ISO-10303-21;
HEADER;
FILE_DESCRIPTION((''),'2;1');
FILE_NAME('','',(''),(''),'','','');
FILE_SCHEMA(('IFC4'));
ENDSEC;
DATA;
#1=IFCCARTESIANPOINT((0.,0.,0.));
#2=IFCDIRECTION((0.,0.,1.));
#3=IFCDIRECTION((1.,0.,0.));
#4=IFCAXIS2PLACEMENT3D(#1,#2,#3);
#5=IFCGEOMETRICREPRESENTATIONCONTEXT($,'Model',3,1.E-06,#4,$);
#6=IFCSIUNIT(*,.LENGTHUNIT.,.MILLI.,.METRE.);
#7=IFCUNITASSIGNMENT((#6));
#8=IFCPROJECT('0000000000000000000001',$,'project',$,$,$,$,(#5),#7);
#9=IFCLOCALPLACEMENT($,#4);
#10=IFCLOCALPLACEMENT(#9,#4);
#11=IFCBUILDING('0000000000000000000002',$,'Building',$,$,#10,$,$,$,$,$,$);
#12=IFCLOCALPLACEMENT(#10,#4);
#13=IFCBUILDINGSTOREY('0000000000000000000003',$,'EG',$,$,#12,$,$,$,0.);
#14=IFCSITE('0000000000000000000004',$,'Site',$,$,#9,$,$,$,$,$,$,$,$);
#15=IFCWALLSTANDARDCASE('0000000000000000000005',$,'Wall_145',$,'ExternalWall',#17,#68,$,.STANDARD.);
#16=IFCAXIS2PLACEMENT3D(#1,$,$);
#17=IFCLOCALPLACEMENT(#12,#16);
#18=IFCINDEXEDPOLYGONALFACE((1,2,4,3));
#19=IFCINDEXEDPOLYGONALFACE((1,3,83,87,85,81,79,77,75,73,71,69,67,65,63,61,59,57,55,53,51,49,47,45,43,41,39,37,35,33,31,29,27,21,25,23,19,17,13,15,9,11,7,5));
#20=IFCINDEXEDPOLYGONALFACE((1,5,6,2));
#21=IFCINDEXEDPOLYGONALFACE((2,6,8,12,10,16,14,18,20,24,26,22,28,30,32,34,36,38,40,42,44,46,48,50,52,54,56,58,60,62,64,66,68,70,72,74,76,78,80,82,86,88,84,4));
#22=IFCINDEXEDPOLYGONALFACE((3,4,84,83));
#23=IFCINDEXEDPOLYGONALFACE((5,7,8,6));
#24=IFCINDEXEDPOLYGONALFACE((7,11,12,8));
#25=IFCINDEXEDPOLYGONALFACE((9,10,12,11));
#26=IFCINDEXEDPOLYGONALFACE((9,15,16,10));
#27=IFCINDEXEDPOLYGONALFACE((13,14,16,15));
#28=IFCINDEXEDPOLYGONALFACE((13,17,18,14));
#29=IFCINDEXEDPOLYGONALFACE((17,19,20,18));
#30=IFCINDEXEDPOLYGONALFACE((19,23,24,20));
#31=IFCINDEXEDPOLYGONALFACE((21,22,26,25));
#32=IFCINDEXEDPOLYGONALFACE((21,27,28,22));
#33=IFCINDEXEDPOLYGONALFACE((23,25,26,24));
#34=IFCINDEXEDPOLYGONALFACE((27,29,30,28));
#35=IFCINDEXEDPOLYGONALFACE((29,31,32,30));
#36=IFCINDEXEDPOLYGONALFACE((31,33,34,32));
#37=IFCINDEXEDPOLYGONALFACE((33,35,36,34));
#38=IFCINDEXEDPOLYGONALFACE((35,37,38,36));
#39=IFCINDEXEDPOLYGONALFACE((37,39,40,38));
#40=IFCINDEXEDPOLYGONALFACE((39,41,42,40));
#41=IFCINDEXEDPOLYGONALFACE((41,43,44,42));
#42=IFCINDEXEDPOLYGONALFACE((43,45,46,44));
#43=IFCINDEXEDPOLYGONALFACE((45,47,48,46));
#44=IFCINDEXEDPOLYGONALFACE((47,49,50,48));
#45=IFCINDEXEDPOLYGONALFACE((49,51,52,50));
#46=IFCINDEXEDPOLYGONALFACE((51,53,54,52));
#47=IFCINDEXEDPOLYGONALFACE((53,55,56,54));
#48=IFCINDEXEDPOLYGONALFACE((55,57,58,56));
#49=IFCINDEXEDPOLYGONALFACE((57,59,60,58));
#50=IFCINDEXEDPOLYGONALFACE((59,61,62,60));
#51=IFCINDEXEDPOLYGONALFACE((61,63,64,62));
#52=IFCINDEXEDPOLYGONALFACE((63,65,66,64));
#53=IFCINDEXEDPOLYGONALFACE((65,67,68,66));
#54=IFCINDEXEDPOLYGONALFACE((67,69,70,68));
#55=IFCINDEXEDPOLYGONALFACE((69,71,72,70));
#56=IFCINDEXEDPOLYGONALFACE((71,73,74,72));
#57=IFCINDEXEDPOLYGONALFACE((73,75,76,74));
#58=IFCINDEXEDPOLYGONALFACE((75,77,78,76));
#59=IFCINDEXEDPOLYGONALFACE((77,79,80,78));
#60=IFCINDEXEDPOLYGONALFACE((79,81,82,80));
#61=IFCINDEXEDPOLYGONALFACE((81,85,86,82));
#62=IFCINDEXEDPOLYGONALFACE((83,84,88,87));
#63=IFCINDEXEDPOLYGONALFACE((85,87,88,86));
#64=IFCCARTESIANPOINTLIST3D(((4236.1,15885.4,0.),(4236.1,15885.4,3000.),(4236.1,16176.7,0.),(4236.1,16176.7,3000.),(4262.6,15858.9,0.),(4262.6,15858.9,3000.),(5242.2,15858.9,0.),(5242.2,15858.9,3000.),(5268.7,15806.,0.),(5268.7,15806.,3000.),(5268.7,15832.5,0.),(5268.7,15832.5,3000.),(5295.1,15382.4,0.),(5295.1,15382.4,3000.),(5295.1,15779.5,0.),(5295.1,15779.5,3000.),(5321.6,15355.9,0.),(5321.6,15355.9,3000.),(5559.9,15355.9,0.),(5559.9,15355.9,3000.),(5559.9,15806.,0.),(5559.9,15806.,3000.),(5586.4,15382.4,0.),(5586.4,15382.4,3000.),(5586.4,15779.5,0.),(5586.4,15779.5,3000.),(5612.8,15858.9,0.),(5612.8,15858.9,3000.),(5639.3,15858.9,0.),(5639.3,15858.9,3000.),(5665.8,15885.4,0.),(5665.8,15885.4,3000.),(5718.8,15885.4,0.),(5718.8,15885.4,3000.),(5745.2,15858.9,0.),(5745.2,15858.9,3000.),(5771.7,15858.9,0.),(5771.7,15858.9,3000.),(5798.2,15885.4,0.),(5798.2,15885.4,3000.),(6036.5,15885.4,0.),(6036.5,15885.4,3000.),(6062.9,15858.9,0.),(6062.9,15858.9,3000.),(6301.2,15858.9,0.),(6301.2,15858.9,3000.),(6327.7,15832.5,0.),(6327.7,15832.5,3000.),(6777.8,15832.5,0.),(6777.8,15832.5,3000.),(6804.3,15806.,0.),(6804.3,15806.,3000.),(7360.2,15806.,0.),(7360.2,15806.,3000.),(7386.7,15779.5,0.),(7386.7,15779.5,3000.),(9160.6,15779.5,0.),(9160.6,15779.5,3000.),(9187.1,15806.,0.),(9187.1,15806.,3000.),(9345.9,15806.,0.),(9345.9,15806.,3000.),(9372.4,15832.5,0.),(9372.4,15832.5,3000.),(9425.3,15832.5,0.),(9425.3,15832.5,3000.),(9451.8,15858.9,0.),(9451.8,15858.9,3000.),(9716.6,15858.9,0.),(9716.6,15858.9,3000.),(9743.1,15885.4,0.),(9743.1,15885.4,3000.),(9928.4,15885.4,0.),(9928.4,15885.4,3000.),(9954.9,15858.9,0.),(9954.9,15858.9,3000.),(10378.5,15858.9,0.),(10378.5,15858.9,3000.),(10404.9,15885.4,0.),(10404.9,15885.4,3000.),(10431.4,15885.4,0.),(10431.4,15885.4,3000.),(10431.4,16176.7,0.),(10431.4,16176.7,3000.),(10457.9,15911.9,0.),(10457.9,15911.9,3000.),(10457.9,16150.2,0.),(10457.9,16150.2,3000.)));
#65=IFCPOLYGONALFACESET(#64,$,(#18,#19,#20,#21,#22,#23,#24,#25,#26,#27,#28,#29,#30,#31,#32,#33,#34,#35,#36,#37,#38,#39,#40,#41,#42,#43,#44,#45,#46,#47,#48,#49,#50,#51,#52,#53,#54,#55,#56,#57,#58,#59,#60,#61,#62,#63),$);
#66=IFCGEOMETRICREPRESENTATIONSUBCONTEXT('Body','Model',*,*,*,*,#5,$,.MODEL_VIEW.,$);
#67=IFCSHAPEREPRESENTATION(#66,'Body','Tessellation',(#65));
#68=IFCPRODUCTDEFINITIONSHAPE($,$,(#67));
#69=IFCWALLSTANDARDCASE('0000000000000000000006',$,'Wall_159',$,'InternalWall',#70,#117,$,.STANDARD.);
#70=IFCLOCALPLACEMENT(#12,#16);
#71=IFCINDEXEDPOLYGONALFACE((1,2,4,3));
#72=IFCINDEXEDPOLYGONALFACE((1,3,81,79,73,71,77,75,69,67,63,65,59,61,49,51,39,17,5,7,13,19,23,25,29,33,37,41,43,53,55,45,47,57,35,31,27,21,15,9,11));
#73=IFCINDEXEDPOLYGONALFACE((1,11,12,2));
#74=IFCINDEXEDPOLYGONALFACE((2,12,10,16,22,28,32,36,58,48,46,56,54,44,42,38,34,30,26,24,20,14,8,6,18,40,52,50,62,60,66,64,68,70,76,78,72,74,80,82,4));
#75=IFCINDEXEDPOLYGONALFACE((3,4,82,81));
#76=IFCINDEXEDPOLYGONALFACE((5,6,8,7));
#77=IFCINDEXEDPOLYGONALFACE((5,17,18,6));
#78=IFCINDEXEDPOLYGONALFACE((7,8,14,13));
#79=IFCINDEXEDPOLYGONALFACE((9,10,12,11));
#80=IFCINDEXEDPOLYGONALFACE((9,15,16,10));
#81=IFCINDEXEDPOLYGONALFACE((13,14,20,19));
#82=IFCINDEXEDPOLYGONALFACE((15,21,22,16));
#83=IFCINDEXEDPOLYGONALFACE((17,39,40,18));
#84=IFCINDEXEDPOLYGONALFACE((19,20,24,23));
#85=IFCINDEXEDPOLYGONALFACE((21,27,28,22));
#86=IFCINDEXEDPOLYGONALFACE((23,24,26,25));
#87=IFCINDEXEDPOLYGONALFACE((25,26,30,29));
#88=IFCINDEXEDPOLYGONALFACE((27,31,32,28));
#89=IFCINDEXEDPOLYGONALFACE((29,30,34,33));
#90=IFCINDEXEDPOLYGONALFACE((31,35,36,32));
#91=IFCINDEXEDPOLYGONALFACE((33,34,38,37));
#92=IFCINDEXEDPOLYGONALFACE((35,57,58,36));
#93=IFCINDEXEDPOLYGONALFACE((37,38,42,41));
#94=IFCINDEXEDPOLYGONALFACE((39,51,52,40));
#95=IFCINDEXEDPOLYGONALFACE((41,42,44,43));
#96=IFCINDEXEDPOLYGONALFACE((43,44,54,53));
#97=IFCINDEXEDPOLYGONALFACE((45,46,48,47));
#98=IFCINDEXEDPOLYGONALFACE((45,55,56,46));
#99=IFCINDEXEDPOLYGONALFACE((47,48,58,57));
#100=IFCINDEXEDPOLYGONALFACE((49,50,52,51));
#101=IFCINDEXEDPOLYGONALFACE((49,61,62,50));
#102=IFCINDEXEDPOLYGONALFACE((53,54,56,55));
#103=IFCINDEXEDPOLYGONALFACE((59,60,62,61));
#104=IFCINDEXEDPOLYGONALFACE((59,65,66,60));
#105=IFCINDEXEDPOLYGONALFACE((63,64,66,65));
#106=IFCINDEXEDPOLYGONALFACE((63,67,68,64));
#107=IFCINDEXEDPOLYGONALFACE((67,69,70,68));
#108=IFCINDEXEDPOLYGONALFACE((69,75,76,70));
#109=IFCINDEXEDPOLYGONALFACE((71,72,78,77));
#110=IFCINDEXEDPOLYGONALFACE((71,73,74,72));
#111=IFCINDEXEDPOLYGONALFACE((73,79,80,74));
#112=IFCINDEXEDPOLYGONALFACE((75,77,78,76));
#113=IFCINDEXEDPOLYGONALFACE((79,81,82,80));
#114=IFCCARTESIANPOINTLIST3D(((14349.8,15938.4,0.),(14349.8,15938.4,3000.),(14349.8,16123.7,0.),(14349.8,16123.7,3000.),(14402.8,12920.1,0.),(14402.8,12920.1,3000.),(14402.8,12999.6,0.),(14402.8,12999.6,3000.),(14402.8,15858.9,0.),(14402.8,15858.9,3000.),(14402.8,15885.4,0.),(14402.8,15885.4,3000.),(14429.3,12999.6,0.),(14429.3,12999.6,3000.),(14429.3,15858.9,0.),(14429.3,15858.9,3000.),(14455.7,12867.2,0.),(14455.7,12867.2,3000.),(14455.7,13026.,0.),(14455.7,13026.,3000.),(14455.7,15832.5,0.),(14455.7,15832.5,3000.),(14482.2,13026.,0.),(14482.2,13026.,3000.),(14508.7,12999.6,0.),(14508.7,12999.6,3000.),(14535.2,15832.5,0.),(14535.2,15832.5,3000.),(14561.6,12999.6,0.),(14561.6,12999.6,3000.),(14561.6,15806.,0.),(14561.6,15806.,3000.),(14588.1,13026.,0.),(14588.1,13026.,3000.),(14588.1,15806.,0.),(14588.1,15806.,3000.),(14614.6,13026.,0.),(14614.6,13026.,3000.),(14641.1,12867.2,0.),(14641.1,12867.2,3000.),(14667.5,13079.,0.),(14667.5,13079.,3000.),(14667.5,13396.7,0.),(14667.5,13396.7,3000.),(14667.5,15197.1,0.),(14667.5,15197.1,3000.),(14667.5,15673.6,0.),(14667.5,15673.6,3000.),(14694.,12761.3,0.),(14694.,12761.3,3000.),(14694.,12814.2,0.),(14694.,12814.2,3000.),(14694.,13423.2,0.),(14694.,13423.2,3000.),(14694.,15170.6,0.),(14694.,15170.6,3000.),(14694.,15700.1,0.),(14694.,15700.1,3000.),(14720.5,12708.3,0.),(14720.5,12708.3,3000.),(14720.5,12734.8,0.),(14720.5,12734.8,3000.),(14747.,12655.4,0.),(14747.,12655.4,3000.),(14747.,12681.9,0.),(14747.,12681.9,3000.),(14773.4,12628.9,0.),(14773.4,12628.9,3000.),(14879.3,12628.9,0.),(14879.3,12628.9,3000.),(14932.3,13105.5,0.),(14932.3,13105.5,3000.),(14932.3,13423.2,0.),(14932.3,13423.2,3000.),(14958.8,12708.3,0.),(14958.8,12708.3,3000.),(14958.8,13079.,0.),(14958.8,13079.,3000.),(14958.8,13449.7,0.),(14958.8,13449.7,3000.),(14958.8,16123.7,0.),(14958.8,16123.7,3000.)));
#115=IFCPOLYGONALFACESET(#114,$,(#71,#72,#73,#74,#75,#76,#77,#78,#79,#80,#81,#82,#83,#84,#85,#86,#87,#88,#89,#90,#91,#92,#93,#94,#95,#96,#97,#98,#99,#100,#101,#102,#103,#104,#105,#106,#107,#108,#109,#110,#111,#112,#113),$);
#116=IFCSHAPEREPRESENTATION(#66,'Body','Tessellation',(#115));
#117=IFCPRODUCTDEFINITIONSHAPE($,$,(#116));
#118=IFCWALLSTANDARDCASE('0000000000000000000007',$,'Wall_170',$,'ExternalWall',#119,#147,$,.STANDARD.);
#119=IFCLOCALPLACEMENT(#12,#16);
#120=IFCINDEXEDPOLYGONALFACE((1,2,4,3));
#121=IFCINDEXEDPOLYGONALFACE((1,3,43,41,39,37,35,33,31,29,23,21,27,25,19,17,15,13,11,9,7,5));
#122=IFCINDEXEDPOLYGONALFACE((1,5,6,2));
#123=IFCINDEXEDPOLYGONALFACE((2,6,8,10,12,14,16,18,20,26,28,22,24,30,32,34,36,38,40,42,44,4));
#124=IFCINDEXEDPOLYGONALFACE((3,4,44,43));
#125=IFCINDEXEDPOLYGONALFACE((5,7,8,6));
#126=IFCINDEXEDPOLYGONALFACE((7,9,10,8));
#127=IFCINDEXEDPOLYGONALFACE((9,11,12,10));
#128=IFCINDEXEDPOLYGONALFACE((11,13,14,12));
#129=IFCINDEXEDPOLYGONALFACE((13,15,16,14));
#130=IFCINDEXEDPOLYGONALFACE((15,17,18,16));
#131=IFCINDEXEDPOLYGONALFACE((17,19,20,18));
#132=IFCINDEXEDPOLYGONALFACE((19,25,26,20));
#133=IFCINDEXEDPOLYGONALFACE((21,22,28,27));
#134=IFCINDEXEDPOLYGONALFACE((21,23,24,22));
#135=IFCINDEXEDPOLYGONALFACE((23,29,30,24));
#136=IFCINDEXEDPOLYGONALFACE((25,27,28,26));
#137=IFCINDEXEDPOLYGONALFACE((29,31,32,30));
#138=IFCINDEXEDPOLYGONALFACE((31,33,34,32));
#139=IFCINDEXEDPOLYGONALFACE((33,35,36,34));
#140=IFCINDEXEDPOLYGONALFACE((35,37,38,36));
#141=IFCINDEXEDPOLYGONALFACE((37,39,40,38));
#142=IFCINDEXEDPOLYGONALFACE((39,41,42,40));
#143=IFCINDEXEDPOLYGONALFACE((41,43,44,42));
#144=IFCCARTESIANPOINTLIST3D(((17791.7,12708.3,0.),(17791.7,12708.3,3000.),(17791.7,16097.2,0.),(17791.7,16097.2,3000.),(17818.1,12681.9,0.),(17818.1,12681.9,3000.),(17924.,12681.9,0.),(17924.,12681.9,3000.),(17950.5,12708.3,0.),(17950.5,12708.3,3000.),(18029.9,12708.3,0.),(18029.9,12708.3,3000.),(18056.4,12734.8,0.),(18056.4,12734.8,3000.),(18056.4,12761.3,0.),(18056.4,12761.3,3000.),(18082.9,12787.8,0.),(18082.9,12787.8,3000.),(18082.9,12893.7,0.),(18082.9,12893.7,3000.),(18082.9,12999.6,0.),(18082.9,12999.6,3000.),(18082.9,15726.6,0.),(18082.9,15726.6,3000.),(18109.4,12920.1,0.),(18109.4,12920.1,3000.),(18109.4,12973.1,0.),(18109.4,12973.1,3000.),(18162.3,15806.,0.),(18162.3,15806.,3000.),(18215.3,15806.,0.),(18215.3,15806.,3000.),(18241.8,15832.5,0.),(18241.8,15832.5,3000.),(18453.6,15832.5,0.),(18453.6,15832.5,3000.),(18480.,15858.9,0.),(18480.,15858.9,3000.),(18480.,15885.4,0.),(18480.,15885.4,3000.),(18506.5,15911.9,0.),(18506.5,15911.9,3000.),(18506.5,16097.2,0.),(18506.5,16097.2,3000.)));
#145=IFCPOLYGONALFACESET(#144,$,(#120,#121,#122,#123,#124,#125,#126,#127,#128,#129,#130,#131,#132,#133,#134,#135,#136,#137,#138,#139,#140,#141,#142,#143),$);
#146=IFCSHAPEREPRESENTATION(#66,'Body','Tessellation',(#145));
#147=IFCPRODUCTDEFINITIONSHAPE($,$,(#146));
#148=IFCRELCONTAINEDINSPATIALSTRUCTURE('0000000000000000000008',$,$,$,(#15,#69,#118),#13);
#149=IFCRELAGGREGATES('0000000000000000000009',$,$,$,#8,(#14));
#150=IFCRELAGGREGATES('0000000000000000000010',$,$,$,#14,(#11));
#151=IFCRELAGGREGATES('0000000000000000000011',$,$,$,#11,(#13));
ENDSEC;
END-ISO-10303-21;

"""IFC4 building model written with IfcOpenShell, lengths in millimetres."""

from ifc_helpers import new_model, si_unit, frame, origin_with_axes, place, context, subcontext, project, spatial, polyline, outline, extrude, element, save


model = new_model("IFC4")

# Units and contexts
model_context = context("Model", 3, precision=1e-06, world=origin_with_axes())
body_context = subcontext(model_context, "Body", "Model", "MODEL_VIEW")
ifc_project = project(units=[si_unit("LENGTHUNIT", "METRE", prefix="MILLI")], contexts=[model_context])

# Site, building, storey
site_placement = place(None, origin_with_axes())
site = spatial("IfcSite", under=ifc_project, at=site_placement, Name="Site")
building_placement = place(site_placement, origin_with_axes())
building = spatial("IfcBuilding", under=site, at=building_placement, Name="Building")
storey_placement = place(building_placement, origin_with_axes())
storey = spatial("IfcBuildingStorey", under=building, at=storey_placement, Name="EG", Elevation=0.0)

# Walls
wall_1_placement = place(storey_placement, origin_with_axes())
element("IfcWallStandardCase", 1, at=wall_1_placement, inside=storey, Name="Wall_145", ObjectType="ExternalWall", PredefinedType="STANDARD", context=body_context, shape_type="SweptSolid", body=[
    extrude(outline(polyline([(5321.6, 15355.9, 0.0), (5295.1, 15382.4, 0.0), (5295.1, 15779.5, 0.0), (5268.7, 15806.0, 0.0), (5268.7, 15832.5, 0.0), (5242.2, 15858.9, 0.0), (4262.6, 15858.9, 0.0), (4236.1, 15885.4, 0.0), (4236.1, 16176.7, 0.0), (10431.4, 16176.7, 0.0), (10457.9, 16150.2, 0.0), (10457.9, 15911.9, 0.0), (10431.4, 15885.4, 0.0), (10404.9, 15885.4, 0.0), (10378.5, 15858.9, 0.0), (9954.9, 15858.9, 0.0), (9928.4, 15885.4, 0.0), (9743.1, 15885.4, 0.0), (9716.6, 15858.9, 0.0), (9451.8, 15858.9, 0.0), (9425.3, 15832.5, 0.0), (9372.4, 15832.5, 0.0), (9345.9, 15806.0, 0.0), (9187.1, 15806.0, 0.0), (9160.6, 15779.5, 0.0), (7386.7, 15779.5, 0.0), (7360.2, 15806.0, 0.0), (6804.3, 15806.0, 0.0), (6777.8, 15832.5, 0.0), (6327.7, 15832.5, 0.0), (6301.2, 15858.9, 0.0), (6062.9, 15858.9, 0.0), (6036.5, 15885.4, 0.0), (5798.2, 15885.4, 0.0), (5771.7, 15858.9, 0.0), (5745.2, 15858.9, 0.0), (5718.8, 15885.4, 0.0), (5665.8, 15885.4, 0.0), (5639.3, 15858.9, 0.0), (5612.8, 15858.9, 0.0), (5559.9, 15806.0, 0.0), (5586.4, 15779.5, 0.0), (5586.4, 15382.4, 0.0), (5559.9, 15355.9, 0.0), (5321.6, 15355.9, 0.0)])), origin_with_axes(), (0.0, 0.0, 1.0), 3000.0),
])
wall_2_placement = place(storey_placement, origin_with_axes())
element("IfcWallStandardCase", 2, at=wall_2_placement, inside=storey, Name="Wall_159", ObjectType="InternalWall", PredefinedType="STANDARD", context=body_context, shape_type="SweptSolid", body=[
    extrude(outline(polyline([(14773.4, 12628.9, 0.0), (14747.0, 12655.4, 0.0), (14747.0, 12681.9, 0.0), (14720.5, 12708.3, 0.0), (14720.5, 12734.8, 0.0), (14694.0, 12761.3, 0.0), (14694.0, 12814.2, 0.0), (14641.1, 12867.2, 0.0), (14455.7, 12867.2, 0.0), (14402.8, 12920.1, 0.0), (14402.8, 12999.6, 0.0), (14429.3, 12999.6, 0.0), (14455.7, 13026.0, 0.0), (14482.2, 13026.0, 0.0), (14508.7, 12999.6, 0.0), (14561.6, 12999.6, 0.0), (14588.1, 13026.0, 0.0), (14614.6, 13026.0, 0.0), (14667.5, 13079.0, 0.0), (14667.5, 13396.7, 0.0), (14694.0, 13423.2, 0.0), (14694.0, 15170.6, 0.0), (14667.5, 15197.1, 0.0), (14667.5, 15673.6, 0.0), (14694.0, 15700.1, 0.0), (14588.1, 15806.0, 0.0), (14561.6, 15806.0, 0.0), (14535.2, 15832.5, 0.0), (14455.7, 15832.5, 0.0), (14429.3, 15858.9, 0.0), (14402.8, 15858.9, 0.0), (14402.8, 15885.4, 0.0), (14349.8, 15938.4, 0.0), (14349.8, 16123.7, 0.0), (14958.8, 16123.7, 0.0), (14958.8, 13449.7, 0.0), (14932.3, 13423.2, 0.0), (14932.3, 13105.5, 0.0), (14958.8, 13079.0, 0.0), (14958.8, 12708.3, 0.0), (14879.3, 12628.9, 0.0), (14773.4, 12628.9, 0.0)])), origin_with_axes(), (0.0, 0.0, 1.0), 3000.0),
])

# Wall
for number, where, z_axis, x_axis, name in (
    (3, (0.0, 0.0, 0.0), (0.0, 0.0, 1.0), (1.0, 0.0, 0.0), "Wall_170"),
):
    element("IfcWallStandardCase", number, at=place(storey_placement, frame(where, z_axis=z_axis, x_axis=x_axis)), inside=storey, Name=name, ObjectType="ExternalWall", PredefinedType="STANDARD", context=body_context, shape_type="SweptSolid", body=[
        extrude(outline(polyline([(17818.1, 12681.9, 0.0), (17791.7, 12708.3, 0.0), (17791.7, 16097.2, 0.0), (18506.5, 16097.2, 0.0), (18506.5, 15911.9, 0.0), (18480.0, 15885.4, 0.0), (18480.0, 15858.9, 0.0), (18453.6, 15832.5, 0.0), (18241.8, 15832.5, 0.0), (18215.3, 15806.0, 0.0), (18162.3, 15806.0, 0.0), (18082.9, 15726.6, 0.0), (18082.9, 12999.6, 0.0), (18109.4, 12973.1, 0.0), (18109.4, 12920.1, 0.0), (18082.9, 12893.7, 0.0), (18082.9, 12787.8, 0.0), (18056.4, 12761.3, 0.0), (18056.4, 12734.8, 0.0), (18029.9, 12708.3, 0.0), (17950.5, 12708.3, 0.0), (17924.0, 12681.9, 0.0), (17818.1, 12681.9, 0.0)])), origin_with_axes(), (0.0, 0.0, 1.0), 3000.0),
    ])

save(model, "model.ifc")
